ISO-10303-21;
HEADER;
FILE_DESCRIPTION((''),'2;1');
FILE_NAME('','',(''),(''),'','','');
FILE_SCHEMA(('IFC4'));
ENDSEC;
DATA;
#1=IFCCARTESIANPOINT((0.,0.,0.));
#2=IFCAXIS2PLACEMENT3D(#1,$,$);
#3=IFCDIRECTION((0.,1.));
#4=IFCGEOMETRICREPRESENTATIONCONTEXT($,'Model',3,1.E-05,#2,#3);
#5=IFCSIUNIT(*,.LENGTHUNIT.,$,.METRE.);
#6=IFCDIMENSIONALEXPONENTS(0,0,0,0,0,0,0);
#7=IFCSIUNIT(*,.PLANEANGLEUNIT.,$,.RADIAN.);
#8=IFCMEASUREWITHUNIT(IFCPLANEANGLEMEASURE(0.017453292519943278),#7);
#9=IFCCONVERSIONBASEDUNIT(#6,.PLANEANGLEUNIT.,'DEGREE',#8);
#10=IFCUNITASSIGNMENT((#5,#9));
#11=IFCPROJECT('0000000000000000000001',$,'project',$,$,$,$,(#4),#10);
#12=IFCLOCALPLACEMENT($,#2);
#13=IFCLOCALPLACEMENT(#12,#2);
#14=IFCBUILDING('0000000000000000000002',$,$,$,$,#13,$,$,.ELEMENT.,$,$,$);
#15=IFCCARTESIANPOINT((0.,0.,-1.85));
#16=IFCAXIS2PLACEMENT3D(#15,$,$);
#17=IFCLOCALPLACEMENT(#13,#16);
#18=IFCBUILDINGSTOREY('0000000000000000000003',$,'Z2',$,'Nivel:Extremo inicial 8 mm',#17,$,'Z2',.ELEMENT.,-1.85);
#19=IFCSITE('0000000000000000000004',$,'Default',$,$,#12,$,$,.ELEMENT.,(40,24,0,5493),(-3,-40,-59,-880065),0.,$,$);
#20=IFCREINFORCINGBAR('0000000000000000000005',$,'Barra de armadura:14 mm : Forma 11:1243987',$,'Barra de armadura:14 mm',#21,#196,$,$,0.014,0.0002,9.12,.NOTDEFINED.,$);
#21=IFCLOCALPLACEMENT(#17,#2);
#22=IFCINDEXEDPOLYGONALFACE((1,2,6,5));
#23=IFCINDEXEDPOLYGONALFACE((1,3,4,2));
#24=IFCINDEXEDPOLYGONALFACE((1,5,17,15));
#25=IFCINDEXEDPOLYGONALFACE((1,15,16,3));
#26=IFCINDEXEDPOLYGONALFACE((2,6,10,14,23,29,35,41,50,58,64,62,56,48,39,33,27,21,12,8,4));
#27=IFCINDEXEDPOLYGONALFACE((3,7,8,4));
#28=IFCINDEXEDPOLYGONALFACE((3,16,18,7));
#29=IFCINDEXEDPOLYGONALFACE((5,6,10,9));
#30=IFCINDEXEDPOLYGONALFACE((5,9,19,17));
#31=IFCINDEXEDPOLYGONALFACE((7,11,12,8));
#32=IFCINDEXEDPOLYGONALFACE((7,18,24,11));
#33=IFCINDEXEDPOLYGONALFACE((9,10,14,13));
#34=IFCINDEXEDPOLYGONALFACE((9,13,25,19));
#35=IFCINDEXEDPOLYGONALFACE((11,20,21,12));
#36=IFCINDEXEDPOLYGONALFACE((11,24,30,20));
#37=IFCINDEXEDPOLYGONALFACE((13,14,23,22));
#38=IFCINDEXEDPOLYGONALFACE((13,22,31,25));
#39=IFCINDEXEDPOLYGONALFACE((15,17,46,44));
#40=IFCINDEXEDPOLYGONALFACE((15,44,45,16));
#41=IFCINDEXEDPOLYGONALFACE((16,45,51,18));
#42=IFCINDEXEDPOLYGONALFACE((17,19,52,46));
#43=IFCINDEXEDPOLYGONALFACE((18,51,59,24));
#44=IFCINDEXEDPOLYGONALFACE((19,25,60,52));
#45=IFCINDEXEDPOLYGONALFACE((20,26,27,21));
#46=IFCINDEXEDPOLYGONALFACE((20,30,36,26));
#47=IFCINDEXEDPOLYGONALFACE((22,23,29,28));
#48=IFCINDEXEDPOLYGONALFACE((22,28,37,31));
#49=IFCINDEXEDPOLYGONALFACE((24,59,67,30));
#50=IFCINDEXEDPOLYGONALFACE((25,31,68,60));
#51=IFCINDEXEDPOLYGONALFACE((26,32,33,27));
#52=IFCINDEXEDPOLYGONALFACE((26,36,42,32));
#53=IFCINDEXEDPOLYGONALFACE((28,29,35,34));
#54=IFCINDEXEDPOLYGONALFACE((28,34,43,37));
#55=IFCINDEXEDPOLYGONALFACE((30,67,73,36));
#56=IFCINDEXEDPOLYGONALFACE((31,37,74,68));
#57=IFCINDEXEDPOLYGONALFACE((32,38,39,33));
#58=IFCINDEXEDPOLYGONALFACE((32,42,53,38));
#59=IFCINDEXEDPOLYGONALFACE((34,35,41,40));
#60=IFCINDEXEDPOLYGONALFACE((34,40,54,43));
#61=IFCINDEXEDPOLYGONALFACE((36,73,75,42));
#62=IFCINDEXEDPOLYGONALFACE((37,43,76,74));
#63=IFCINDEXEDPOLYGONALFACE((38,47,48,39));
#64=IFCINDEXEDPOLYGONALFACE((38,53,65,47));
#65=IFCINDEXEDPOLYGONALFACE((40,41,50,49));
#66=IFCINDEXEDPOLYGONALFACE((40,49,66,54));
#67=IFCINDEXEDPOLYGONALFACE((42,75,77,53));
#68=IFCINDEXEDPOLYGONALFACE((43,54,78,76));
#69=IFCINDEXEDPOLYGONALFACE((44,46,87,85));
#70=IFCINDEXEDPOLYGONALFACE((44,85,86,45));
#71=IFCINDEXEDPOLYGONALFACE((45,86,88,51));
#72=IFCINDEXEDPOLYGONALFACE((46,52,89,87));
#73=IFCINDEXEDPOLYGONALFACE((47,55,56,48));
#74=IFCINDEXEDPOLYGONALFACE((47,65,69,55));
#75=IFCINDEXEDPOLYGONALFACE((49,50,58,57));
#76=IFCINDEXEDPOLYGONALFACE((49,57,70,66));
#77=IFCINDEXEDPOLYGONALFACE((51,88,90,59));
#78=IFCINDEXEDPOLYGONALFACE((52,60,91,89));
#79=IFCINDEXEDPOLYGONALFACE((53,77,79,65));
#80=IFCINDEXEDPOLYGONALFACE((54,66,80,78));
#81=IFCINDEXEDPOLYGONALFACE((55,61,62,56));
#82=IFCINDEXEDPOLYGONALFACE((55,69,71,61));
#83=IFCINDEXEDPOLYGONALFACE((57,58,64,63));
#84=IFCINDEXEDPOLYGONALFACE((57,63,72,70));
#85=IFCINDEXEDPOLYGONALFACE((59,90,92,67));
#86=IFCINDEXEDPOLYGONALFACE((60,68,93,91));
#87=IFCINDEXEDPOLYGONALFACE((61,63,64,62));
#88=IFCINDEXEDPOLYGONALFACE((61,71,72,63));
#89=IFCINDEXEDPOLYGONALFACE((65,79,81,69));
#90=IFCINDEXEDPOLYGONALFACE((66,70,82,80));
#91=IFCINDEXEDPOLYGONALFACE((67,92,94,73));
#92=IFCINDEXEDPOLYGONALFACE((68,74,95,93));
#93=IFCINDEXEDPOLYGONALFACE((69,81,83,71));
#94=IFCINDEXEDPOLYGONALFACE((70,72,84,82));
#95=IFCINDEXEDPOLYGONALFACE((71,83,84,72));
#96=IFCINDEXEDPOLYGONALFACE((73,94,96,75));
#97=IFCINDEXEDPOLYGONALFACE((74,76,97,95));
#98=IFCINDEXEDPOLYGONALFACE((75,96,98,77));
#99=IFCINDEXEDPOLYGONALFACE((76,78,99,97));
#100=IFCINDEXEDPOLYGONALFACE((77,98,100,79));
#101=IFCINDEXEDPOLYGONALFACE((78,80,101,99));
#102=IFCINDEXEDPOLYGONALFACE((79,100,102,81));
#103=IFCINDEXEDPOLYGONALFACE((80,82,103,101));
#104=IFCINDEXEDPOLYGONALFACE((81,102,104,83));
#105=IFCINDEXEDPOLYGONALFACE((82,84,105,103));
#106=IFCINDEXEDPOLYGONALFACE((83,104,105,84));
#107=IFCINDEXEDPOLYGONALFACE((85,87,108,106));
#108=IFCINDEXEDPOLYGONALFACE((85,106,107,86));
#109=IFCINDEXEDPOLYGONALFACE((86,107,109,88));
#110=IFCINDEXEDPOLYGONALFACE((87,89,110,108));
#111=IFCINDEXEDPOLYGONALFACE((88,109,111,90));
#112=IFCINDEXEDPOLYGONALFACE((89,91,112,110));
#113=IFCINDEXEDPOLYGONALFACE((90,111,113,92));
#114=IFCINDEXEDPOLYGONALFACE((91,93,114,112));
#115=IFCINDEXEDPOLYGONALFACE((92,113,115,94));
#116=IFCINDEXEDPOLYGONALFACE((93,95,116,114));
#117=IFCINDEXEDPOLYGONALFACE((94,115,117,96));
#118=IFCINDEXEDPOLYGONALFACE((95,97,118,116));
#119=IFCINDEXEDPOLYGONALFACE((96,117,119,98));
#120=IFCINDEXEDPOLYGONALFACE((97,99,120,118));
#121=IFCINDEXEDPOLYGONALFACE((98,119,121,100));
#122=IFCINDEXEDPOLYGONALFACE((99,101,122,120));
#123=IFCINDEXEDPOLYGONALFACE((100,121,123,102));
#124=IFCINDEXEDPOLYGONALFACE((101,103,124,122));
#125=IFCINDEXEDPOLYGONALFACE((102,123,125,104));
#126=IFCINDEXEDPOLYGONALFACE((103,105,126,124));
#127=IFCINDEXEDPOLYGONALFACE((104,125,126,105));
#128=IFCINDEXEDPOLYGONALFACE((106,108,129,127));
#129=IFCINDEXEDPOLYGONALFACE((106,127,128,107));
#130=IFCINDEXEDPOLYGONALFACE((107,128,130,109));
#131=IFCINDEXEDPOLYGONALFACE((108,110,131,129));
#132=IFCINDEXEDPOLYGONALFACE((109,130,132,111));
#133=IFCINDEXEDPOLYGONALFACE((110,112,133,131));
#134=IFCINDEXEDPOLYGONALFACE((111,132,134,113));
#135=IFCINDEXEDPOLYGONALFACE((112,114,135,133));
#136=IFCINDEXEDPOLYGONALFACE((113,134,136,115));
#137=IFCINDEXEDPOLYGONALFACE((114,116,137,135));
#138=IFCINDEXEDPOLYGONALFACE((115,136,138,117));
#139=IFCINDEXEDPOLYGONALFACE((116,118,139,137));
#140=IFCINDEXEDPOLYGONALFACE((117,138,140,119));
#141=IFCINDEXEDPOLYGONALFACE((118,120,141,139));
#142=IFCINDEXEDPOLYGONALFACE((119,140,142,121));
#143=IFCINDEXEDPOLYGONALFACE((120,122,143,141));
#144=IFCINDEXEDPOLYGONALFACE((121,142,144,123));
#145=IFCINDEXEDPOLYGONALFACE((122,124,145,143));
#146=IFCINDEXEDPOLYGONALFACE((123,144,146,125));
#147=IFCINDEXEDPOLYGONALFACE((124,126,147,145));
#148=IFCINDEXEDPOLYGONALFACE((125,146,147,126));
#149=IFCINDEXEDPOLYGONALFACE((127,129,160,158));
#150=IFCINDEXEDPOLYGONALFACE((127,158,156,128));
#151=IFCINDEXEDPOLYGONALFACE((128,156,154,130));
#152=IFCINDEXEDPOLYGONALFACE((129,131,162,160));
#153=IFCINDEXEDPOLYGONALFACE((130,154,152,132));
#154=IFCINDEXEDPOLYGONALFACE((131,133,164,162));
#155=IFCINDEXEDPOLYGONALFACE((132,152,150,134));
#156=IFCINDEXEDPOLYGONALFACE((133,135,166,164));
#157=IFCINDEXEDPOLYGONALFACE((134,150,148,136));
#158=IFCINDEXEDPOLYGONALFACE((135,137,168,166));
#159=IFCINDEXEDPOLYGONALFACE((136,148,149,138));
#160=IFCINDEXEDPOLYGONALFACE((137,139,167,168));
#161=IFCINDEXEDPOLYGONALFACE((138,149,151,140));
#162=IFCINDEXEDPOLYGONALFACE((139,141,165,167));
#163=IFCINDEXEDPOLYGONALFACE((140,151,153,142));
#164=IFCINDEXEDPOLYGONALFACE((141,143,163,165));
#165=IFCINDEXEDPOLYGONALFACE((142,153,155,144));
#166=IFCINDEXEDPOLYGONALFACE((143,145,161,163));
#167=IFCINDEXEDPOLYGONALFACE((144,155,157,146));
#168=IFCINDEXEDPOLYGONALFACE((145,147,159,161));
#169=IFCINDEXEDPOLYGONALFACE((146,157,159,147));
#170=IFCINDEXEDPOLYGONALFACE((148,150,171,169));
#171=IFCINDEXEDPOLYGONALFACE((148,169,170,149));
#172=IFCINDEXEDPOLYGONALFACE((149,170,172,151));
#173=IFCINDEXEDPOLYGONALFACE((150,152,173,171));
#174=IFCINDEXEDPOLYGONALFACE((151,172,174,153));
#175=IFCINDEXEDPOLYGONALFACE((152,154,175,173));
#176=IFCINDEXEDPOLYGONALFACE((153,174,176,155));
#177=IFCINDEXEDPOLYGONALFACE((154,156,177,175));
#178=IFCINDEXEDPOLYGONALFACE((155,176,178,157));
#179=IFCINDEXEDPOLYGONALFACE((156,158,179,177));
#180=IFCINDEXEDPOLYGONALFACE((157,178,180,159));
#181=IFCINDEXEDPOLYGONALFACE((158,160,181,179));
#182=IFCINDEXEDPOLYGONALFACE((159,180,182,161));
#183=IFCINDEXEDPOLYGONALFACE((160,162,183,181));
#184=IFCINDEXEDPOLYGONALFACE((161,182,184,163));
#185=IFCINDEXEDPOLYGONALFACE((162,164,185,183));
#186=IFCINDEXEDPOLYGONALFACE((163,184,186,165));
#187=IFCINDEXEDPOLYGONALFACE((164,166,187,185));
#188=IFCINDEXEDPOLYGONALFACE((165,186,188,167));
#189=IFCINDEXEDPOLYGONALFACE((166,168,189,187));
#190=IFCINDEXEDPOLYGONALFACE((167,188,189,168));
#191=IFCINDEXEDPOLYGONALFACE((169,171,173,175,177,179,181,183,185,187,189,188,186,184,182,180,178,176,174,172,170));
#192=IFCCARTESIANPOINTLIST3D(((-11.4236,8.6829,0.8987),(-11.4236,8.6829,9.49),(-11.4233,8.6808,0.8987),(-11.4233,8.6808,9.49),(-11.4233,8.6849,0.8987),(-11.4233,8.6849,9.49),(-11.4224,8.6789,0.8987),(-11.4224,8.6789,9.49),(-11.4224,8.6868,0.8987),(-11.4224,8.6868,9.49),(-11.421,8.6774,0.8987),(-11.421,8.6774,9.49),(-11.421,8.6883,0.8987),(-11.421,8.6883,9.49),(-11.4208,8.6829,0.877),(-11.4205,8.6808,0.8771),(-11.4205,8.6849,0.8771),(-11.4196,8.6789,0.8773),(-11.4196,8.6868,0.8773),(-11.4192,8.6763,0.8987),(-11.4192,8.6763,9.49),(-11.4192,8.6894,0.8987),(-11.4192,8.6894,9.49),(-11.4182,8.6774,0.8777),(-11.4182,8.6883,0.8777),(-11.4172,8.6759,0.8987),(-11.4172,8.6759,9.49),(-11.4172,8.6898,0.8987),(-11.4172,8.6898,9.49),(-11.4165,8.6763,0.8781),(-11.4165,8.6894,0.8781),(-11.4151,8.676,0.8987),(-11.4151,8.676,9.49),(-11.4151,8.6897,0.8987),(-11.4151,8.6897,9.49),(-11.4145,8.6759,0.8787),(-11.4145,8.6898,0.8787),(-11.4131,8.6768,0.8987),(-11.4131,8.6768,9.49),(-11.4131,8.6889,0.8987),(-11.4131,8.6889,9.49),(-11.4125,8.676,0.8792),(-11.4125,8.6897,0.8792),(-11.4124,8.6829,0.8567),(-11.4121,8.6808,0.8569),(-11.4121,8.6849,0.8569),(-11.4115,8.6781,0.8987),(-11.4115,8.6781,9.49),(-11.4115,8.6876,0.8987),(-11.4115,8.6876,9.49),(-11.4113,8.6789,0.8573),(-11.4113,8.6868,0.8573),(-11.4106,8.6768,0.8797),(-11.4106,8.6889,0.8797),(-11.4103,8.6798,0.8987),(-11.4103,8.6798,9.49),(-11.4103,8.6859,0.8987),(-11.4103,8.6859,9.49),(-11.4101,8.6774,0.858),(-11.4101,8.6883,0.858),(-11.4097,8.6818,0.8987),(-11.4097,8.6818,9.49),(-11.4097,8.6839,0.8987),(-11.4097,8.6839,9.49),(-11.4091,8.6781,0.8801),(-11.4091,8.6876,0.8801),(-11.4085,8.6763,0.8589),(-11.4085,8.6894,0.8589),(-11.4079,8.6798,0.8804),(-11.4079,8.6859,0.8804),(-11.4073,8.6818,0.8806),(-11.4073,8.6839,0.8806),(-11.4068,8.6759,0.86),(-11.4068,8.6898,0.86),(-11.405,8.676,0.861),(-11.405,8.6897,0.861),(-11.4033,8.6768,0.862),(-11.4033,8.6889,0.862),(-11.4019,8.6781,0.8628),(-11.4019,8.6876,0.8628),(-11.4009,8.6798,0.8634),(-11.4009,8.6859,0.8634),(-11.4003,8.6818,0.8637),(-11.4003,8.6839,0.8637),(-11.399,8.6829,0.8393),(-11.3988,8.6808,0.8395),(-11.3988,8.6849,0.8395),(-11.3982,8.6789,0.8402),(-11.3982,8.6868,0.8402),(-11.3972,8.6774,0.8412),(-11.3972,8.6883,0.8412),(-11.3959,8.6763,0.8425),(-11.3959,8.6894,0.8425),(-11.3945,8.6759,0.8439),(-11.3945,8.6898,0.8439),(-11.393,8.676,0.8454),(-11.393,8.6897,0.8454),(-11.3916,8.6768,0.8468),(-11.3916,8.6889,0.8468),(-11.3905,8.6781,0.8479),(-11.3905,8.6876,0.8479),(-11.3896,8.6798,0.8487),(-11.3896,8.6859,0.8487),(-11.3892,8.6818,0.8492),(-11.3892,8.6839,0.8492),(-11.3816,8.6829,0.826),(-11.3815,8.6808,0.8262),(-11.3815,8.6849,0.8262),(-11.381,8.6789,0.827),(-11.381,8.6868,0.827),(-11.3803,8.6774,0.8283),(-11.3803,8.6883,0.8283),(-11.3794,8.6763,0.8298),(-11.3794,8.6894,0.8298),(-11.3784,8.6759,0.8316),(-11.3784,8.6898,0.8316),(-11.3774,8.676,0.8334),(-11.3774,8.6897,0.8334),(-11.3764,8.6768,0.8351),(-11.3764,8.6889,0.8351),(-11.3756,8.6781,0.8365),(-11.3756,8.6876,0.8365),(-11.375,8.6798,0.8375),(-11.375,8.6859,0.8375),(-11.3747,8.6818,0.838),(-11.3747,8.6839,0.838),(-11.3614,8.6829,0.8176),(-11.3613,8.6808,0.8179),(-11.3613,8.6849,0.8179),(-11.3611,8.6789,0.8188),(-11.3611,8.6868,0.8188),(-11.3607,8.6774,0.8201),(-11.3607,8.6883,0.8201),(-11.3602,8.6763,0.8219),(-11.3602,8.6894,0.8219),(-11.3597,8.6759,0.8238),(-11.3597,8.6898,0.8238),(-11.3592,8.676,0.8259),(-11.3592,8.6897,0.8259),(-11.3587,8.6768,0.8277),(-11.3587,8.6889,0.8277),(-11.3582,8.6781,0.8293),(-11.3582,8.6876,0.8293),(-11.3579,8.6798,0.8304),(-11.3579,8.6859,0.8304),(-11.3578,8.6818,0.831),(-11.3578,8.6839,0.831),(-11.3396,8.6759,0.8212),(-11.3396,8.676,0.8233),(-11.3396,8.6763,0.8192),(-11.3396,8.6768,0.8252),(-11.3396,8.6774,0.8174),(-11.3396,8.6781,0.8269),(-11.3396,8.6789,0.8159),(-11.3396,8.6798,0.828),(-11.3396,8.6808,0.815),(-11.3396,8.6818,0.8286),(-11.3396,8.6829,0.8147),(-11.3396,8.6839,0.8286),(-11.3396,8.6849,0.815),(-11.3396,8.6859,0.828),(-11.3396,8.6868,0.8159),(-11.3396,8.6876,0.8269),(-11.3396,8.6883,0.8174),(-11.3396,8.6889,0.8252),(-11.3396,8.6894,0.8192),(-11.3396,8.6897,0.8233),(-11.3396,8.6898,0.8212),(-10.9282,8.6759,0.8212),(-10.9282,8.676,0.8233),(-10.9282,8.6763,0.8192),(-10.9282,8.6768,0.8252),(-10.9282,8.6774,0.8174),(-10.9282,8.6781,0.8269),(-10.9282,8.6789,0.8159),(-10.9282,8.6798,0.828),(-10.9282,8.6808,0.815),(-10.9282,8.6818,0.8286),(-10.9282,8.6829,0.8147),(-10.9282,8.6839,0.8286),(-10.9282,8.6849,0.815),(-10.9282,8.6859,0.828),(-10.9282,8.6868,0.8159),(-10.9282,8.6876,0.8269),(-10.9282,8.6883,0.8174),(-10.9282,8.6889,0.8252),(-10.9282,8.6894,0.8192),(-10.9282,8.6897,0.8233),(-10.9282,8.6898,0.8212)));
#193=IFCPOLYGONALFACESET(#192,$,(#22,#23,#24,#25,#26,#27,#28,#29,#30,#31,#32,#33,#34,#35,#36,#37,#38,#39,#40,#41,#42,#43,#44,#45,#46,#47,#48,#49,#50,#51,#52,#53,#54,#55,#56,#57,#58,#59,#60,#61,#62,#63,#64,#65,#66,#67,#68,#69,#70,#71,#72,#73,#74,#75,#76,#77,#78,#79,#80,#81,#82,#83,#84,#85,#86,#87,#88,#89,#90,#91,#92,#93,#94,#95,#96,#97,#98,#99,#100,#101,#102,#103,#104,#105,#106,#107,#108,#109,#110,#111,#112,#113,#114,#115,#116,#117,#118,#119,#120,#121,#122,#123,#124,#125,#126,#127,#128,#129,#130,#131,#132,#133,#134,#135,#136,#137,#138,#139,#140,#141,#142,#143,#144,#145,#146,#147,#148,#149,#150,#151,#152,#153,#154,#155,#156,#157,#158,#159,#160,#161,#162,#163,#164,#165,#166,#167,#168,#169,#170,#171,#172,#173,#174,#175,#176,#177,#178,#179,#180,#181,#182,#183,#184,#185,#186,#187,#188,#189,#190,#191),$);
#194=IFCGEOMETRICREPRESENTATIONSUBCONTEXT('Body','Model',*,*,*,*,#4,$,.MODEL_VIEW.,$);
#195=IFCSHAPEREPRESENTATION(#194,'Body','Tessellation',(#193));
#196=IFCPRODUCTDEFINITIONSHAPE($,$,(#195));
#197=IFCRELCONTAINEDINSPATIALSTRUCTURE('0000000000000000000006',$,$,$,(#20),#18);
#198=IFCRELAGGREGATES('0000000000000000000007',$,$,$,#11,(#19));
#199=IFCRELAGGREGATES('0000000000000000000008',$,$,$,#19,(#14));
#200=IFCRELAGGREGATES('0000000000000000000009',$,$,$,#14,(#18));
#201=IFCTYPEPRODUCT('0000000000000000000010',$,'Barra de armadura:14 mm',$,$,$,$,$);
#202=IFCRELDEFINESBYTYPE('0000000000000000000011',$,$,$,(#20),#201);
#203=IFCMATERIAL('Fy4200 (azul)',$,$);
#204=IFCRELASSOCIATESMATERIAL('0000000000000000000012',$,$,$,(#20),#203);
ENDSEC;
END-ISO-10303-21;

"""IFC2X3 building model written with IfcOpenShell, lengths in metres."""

from ifc_helpers import new_model, entity, si_unit, converted_unit, direction, frame, origin, place, context, subcontext, project, spatial, material, type_object, element, save


model = new_model("IFC2X3")

# Units and contexts
model_context = context("Model", 3, precision=1e-05, world=origin(), true_north=direction((0.0, 1.0)))
body_context = subcontext(model_context, "Body", "Model", "MODEL_VIEW")
ifc_project = project(units=[si_unit("LENGTHUNIT", "METRE"), converted_unit("PLANEANGLEUNIT", "DEGREE", entity("IfcPlaneAngleMeasure", 0.017453292519943278), si_unit("PLANEANGLEUNIT", "RADIAN"), dimensions=[0, 0, 0, 0, 0, 0, 0])], contexts=[model_context])

# Site, building, storey
site_placement = place(None, origin())
site = spatial("IfcSite", under=ifc_project, at=site_placement, Name="Default", CompositionType="ELEMENT", RefLatitude=(40, 24, 0, 5493), RefLongitude=(-3, -40, -59, -880065), RefElevation=0.0)
building_placement = place(site_placement, origin())
building = spatial("IfcBuilding", under=site, at=building_placement, CompositionType="ELEMENT")
storey_placement = place(building_placement, frame((0.0, 0.0, -1.85)))
storey = spatial("IfcBuildingStorey", under=building, at=storey_placement, Name="Z2", ObjectType="Nivel:Extremo inicial 8 mm", LongName="Z2", CompositionType="ELEMENT", Elevation=-1.85)

# Reinforcing bar
ifc_material_1 = material(Name="Fy4200 (azul)")
type_product_1 = type_object("IfcTypeProduct", Name="Barra de armadura:14 mm")
reinforcing_bar_1_placement = place(storey_placement, origin())
element("IfcReinforcingBar", 1, at=reinforcing_bar_1_placement, inside=storey, type_object=type_product_1, material=ifc_material_1, Name="Barra de armadura:14 mm : Forma 11:1243987", ObjectType="Barra de armadura:14 mm", BarLength=9.12, BarRole="NOTDEFINED", CrossSectionArea=0.0002, NominalDiameter=0.014, context=body_context, shape_type="AdvancedSweptSolid", body=[
    entity("IfcSweptDiskSolid", entity("IfcCompositeCurve", [entity("IfcCompositeCurveSegment", "CONTINUOUS", True, entity("IfcPolyline", [entity("IfcCartesianPoint", [-11.4166, 8.6829, 9.49]), entity("IfcCartesianPoint", [-11.4166, 8.6829, 0.8987])])), entity("IfcCompositeCurveSegment", "CONTINUOUS", True, entity("IfcTrimmedCurve", entity("IfcCircle", entity("IfcAxis2Placement3D", entity("IfcCartesianPoint", [-11.3396, 8.6829, 0.8987]), entity("IfcDirection", [0.0, -1.0, 0.0]), entity("IfcDirection", [0.0, 0.0, -1.0])), 0.077), [entity("IfcParameterValue", 270.0)], [entity("IfcParameterValue", 360.0)], True, "PARAMETER")), entity("IfcCompositeCurveSegment", "CONTINUOUS", True, entity("IfcPolyline", [entity("IfcCartesianPoint", [-11.3396, 8.6829, 0.8217]), entity("IfcCartesianPoint", [-10.9282, 8.6829, 0.8217])]))], False), 0.007, None, 0.0, 92.0),
])

save(model, "model.ifc")
